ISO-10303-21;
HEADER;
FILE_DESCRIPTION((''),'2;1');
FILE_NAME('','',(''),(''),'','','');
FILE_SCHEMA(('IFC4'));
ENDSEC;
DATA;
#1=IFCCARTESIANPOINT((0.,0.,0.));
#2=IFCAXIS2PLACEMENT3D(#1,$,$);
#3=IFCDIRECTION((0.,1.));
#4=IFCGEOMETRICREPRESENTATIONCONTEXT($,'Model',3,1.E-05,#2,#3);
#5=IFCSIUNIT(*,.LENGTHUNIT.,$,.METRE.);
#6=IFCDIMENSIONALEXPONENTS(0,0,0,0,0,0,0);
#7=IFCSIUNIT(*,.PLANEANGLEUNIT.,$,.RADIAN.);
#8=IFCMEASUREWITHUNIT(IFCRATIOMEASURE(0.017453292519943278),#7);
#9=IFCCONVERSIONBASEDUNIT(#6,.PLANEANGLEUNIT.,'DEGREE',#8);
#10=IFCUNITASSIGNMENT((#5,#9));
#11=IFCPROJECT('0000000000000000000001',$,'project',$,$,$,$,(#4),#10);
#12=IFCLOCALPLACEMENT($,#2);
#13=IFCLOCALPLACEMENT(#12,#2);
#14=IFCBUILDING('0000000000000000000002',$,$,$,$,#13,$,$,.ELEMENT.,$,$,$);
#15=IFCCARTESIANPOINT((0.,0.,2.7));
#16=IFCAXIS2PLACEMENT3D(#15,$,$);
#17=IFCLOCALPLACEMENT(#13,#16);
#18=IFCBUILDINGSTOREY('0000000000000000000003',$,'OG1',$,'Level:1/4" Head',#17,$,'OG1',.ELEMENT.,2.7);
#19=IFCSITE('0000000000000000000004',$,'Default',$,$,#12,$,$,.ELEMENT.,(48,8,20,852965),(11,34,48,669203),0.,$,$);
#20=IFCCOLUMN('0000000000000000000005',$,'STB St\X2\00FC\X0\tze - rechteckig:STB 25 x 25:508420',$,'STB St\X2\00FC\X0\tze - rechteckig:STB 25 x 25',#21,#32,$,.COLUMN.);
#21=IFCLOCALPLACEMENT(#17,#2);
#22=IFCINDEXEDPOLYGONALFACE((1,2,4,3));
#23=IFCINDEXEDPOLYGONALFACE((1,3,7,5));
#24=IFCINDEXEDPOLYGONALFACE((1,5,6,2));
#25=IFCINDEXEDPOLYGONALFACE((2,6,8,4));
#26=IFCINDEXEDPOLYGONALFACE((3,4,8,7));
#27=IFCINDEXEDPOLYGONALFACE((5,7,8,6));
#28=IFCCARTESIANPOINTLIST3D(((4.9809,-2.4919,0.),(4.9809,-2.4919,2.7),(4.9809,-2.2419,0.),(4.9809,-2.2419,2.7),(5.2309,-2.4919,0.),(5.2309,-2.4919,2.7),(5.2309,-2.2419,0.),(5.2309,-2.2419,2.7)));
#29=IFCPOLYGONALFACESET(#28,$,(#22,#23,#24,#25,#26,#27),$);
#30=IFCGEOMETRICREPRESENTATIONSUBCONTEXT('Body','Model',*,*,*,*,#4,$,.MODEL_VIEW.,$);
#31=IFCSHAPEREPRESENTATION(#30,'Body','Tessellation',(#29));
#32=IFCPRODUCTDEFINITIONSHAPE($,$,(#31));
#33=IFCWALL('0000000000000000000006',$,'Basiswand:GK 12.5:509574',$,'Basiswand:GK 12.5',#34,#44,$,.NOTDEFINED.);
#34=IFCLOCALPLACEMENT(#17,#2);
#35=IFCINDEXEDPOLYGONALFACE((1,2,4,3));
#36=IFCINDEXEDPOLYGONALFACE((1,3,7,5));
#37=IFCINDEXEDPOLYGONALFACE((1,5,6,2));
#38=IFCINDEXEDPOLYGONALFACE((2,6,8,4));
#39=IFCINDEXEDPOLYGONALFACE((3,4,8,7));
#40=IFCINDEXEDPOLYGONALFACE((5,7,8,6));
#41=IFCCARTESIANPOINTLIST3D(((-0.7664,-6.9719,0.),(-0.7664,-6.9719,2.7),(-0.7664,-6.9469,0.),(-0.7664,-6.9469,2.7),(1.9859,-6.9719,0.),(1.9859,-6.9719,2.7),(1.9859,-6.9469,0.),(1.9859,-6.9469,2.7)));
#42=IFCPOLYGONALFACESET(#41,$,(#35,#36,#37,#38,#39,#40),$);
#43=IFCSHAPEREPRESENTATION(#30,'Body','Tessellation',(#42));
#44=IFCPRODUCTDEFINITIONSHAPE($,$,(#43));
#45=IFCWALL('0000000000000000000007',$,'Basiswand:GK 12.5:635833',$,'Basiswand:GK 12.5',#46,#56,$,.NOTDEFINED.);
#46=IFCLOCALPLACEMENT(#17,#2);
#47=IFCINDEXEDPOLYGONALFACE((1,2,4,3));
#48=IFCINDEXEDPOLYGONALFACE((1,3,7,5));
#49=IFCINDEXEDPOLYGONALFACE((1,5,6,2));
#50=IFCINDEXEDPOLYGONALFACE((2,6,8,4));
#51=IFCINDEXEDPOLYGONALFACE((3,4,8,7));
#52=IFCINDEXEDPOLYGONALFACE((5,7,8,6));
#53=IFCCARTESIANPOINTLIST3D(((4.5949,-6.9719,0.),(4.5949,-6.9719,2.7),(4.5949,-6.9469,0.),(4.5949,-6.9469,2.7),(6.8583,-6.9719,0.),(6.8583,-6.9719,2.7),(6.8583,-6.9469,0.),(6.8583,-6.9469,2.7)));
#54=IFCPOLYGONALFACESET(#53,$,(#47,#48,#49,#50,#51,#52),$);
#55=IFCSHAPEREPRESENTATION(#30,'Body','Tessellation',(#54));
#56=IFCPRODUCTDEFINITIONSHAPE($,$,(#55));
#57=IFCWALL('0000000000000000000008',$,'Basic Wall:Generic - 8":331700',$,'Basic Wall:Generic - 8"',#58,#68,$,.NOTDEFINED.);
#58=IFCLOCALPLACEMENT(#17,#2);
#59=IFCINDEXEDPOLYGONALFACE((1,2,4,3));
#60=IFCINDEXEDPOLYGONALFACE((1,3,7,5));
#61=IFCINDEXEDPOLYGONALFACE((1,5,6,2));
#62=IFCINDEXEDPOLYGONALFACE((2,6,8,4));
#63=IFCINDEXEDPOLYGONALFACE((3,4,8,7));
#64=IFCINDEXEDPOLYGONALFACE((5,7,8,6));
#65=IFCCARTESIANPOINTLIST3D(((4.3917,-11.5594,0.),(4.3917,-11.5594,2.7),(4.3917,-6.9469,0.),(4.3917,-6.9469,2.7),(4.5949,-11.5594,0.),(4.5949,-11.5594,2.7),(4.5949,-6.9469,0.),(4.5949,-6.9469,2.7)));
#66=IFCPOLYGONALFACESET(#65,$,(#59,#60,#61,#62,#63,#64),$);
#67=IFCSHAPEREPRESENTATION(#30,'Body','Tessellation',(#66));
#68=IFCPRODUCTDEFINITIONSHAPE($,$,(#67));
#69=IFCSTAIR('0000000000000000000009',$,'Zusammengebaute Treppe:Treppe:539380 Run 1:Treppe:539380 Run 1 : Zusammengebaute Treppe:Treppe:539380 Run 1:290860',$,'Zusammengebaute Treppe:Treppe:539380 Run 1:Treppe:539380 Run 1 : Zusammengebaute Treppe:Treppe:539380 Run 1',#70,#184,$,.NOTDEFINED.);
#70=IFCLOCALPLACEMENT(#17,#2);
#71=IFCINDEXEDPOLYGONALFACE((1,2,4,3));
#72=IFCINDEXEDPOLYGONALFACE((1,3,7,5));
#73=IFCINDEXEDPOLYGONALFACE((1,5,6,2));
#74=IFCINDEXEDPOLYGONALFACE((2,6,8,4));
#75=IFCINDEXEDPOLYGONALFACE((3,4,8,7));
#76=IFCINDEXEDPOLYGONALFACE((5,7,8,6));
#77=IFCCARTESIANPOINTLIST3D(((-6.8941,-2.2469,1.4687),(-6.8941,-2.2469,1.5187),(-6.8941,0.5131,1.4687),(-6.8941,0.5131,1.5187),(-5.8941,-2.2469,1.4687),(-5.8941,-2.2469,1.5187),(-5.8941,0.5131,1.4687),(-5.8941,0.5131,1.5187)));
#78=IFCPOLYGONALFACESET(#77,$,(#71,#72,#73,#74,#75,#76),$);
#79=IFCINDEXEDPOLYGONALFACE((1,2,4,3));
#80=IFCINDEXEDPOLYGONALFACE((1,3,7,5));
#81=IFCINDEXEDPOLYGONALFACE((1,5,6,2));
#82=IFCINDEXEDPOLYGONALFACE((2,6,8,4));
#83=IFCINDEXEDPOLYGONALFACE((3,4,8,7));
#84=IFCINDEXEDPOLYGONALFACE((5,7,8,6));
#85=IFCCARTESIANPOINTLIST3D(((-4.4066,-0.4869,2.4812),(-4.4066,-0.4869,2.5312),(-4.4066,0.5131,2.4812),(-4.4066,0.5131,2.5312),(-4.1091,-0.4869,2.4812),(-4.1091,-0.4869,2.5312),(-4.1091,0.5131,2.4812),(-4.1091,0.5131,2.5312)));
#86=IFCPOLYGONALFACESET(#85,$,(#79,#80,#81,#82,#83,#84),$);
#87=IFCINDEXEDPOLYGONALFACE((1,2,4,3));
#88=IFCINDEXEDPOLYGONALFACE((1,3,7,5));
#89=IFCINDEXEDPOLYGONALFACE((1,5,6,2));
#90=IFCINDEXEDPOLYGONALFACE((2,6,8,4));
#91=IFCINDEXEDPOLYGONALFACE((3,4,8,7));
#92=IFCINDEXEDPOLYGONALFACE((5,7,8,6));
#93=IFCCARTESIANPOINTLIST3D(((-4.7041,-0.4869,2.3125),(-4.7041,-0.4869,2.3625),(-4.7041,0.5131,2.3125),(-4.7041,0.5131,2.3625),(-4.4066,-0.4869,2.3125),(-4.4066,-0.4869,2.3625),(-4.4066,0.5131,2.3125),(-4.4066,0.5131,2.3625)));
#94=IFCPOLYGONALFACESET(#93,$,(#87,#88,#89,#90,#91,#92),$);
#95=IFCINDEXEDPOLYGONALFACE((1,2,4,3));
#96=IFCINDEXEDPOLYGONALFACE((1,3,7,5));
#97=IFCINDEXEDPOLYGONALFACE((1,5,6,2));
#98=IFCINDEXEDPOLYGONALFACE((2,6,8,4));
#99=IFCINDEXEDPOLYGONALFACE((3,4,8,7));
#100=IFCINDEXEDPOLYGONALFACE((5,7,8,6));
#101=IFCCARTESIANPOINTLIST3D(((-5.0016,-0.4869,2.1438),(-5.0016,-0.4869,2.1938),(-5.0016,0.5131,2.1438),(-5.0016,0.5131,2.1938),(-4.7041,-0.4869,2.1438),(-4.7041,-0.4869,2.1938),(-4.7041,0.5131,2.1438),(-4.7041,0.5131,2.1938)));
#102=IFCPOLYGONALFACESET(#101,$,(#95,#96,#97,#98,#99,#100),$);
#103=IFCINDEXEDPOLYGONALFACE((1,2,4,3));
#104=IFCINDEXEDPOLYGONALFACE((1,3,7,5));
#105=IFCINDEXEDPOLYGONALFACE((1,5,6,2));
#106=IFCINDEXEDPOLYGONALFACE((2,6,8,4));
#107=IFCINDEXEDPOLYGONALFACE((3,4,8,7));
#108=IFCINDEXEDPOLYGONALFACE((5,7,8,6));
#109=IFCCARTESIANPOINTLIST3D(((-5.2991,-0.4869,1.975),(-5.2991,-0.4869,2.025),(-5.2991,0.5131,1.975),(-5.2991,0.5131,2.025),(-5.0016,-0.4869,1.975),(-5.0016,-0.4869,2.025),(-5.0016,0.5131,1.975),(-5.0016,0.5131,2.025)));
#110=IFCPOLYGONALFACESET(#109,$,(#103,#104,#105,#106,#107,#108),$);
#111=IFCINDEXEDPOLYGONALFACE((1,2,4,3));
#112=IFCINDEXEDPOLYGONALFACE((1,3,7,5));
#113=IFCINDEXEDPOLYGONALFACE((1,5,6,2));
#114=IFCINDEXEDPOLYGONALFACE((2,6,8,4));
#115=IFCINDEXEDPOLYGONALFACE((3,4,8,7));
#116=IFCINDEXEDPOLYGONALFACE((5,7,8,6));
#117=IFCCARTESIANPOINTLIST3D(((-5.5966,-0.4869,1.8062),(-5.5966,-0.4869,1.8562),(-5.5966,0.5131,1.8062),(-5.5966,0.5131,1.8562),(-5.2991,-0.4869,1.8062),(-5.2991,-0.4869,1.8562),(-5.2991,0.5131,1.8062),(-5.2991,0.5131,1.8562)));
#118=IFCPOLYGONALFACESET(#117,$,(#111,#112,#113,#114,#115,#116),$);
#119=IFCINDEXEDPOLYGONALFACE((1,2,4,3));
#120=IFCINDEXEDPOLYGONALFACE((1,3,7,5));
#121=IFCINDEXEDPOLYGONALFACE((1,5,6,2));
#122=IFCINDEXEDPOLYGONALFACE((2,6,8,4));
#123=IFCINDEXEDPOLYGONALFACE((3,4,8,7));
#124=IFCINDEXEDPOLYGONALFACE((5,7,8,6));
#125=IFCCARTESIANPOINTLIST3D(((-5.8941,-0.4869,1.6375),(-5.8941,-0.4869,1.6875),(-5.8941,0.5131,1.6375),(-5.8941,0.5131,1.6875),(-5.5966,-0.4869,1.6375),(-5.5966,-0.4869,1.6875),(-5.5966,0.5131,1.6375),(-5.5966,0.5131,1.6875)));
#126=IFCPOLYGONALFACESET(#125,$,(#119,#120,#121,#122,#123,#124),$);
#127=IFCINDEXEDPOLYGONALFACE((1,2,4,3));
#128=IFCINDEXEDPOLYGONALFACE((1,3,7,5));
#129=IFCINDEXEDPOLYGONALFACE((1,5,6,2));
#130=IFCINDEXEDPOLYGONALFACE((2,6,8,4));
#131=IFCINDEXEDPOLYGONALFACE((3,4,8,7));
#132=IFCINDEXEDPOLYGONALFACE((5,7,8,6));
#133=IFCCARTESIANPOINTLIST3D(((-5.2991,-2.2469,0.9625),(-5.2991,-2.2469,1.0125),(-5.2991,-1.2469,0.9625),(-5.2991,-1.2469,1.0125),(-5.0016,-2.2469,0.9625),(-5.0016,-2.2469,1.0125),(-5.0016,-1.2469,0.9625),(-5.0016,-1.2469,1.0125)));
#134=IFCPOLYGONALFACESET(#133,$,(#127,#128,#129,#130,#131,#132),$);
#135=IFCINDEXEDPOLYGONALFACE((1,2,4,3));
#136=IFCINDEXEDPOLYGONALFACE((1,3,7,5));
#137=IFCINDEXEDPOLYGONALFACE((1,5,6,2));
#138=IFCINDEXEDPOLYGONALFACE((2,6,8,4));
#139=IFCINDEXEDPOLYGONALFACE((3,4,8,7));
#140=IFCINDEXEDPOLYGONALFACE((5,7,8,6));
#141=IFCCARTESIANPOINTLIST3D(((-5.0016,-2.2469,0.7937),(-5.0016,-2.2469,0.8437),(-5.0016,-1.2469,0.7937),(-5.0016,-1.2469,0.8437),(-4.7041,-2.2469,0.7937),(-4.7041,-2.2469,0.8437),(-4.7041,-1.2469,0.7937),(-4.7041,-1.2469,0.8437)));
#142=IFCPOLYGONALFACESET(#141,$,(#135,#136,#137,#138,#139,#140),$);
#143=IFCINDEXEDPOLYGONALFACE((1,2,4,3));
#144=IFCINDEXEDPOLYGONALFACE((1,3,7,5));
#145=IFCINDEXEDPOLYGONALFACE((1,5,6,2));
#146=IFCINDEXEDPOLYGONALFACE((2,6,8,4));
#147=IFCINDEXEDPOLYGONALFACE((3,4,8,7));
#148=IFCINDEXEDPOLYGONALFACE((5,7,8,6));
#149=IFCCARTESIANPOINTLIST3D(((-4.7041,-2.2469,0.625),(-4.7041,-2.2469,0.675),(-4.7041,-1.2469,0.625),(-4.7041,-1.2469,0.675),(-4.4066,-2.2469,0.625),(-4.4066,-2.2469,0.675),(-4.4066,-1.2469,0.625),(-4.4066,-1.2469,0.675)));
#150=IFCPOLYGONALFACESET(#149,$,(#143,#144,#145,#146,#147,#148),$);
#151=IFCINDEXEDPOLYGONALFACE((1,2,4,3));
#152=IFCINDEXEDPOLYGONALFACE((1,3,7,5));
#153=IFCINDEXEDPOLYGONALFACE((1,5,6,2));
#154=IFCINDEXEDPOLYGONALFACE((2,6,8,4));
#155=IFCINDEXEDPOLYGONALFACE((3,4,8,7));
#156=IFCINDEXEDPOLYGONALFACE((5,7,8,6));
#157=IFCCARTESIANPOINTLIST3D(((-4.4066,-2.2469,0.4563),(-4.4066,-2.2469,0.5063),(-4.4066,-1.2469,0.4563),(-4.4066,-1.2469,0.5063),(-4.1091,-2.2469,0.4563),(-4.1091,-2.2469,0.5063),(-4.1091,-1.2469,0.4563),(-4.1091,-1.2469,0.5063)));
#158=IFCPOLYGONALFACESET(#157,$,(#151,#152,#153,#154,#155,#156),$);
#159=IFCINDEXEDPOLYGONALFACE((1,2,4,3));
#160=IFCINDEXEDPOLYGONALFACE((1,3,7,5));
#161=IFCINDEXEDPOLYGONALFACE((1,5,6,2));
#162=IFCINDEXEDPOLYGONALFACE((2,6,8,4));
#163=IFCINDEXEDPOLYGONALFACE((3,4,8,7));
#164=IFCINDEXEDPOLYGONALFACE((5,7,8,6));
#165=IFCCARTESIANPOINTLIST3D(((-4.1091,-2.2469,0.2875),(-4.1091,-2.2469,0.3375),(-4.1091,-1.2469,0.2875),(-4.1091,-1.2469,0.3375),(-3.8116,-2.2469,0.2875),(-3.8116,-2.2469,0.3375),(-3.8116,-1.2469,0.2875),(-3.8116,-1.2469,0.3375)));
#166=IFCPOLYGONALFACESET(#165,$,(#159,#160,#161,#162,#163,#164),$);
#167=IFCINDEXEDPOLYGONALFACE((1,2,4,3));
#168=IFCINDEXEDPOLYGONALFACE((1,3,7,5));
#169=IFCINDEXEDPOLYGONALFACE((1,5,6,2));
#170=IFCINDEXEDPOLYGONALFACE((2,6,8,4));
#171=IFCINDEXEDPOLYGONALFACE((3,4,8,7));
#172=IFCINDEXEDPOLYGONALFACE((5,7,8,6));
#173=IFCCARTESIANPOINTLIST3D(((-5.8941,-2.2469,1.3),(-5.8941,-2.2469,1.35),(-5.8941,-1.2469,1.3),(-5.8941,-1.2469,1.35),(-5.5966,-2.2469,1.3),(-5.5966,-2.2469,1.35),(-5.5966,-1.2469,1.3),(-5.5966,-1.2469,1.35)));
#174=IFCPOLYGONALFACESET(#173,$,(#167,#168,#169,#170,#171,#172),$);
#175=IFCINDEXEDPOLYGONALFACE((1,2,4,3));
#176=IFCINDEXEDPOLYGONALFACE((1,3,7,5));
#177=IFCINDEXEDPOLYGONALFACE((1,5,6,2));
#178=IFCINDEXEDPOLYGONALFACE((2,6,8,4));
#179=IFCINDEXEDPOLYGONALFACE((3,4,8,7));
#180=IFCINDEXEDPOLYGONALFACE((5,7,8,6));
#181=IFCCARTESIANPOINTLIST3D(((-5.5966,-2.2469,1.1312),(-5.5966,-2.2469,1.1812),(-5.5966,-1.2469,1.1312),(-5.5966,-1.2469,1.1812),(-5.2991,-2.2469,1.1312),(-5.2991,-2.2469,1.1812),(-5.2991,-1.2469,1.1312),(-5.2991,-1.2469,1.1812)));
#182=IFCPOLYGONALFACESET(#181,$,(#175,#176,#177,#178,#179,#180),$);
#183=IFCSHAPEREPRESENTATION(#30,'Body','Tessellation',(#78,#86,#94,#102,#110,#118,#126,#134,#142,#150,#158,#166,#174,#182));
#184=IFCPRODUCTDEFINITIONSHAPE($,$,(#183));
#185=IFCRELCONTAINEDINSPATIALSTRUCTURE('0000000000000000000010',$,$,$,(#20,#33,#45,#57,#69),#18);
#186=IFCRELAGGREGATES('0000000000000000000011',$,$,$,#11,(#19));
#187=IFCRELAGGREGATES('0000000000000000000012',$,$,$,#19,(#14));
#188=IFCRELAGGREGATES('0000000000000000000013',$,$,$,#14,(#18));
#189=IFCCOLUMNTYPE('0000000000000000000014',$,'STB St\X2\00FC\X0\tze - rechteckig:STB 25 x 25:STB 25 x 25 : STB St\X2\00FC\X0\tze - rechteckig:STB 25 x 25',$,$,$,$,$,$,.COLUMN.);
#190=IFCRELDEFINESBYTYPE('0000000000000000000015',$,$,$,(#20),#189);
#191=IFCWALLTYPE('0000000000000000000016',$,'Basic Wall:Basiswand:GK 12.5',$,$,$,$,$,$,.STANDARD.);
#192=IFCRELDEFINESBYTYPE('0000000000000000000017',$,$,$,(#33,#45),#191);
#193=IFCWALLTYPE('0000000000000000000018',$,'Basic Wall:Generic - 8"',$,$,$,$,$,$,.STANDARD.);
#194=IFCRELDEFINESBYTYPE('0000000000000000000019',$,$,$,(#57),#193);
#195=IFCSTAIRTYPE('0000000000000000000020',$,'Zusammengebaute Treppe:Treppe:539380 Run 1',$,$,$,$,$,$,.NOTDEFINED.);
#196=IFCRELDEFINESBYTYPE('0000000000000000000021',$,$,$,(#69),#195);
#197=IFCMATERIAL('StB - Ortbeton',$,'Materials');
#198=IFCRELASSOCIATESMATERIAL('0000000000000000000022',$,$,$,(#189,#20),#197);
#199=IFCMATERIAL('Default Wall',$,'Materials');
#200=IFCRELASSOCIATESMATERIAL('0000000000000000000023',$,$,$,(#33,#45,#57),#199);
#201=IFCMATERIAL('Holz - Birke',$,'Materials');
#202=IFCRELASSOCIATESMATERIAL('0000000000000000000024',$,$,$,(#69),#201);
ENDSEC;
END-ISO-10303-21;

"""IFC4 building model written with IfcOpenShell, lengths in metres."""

from ifc_helpers import new_model, entity, si_unit, converted_unit, direction, frame, origin, place, context, subcontext, project, spatial, indexed_curve, outline, extrude, source, transform, mapped, material, type_object, type_shapes, element, save


model = new_model("IFC4")

# Units and contexts
model_context = context("Model", 3, precision=1e-05, world=origin(), true_north=direction((0.0, 1.0)))
body_context = subcontext(model_context, "Body", "Model", "MODEL_VIEW")
ifc_project = project(units=[si_unit("LENGTHUNIT", "METRE"), converted_unit("PLANEANGLEUNIT", "DEGREE", entity("IfcRatioMeasure", 0.017453292519943278), si_unit("PLANEANGLEUNIT", "RADIAN"), dimensions=[0, 0, 0, 0, 0, 0, 0])], contexts=[model_context])

# Site, building, storey
site_placement = place(None, origin())
site = spatial("IfcSite", under=ifc_project, at=site_placement, Name="Default", CompositionType="ELEMENT", RefLatitude=(48, 8, 20, 852965), RefLongitude=(11, 34, 48, 669203), RefElevation=0.0)
building_placement = place(site_placement, origin())
building = spatial("IfcBuilding", under=site, at=building_placement, CompositionType="ELEMENT")
storey_placement = place(building_placement, frame((0.0, 0.0, 2.7)))
storey = spatial("IfcBuildingStorey", under=building, at=storey_placement, Name="OG1", ObjectType="Level:1/4\" Head", LongName="OG1", CompositionType="ELEMENT", Elevation=2.7)

# Column
ifc_material_1 = material(Name="StB - Ortbeton", Category="Materials")
column_type = type_object("IfcColumnType", Name="STB Stütze - rechteckig:STB 25 x 25:STB 25 x 25 : STB Stütze - rechteckig:STB 25 x 25", PredefinedType="COLUMN", material=ifc_material_1)
shared_shape_1 = source(origin(), body_context, "Body", "SweptSolid", [
    extrude(outline(indexed_curve([(-0.125, -0.125), (0.125, -0.125), (0.125, 0.125), (-0.125, 0.125), (-0.125, -0.125)], self_intersect=False)), frame((0.0, 0.0, 2.7), z_axis=(0.0, 0.0, 1.0), x_axis=(0.0, -1.0, 0.0)), (0.0, 0.0, 1.0), 2.7),
])
type_shapes(column_type, [shared_shape_1])
column_placement = place(storey_placement, frame((5.1059, -2.3669, -2.7)))
element("IfcColumn", 1, at=column_placement, inside=storey, type_object=column_type, material=ifc_material_1, Name="STB Stütze - rechteckig:STB 25 x 25:508420", ObjectType="STB Stütze - rechteckig:STB 25 x 25", PredefinedType="COLUMN", context=body_context, shape_type="MappedRepresentation", body=[
    mapped(shared_shape_1, transform((0.0, 0.0, 0.0), scale=1.0)),
])

# Walls
ifc_material_2 = material(Name="Default Wall", Category="Materials")
wall_type_1 = type_object("IfcWallType", Name="Basic Wall:Basiswand:GK 12.5", PredefinedType="STANDARD")
wall_1_placement = place(storey_placement, frame((1.9859, -6.9594, 0.0), z_axis=(0.0, 0.0, 1.0), x_axis=(-1.0, 0.0, 0.0)))
element("IfcWall", 2, at=wall_1_placement, inside=storey, type_object=wall_type_1, material=ifc_material_2, Name="Basiswand:GK 12.5:509574", ObjectType="Basiswand:GK 12.5", PredefinedType="NOTDEFINED", context=body_context, shape_type="SweptSolid", body=[
    extrude(outline(indexed_curve([(2.7524, 0.0125), (0.0, 0.0125), (0.0, -0.0125), (2.7524, -0.0125), (2.7524, 0.0125)], self_intersect=False)), origin(), (0.0, 0.0, 1.0), 2.7),
])
wall_2_placement = place(storey_placement, frame((4.5949, -6.9594, 0.0)))
element("IfcWall", 3, at=wall_2_placement, inside=storey, type_object=wall_type_1, material=ifc_material_2, Name="Basiswand:GK 12.5:635833", ObjectType="Basiswand:GK 12.5", PredefinedType="NOTDEFINED", context=body_context, shape_type="SweptSolid", body=[
    extrude(outline(indexed_curve([(2.2634, 0.0125), (0.0, 0.0125), (0.0, -0.0125), (2.2634, -0.0125), (2.2634, 0.0125)], self_intersect=False)), origin(), (0.0, 0.0, 1.0), 2.7),
])
wall_type_2 = type_object("IfcWallType", Name="Basic Wall:Generic - 8\"", PredefinedType="STANDARD")
wall_3_placement = place(storey_placement, frame((4.4933, -6.9469, 0.0), z_axis=(0.0, 0.0, 1.0), x_axis=(0.0, -1.0, 0.0)))
element("IfcWall", 4, at=wall_3_placement, inside=storey, type_object=wall_type_2, material=ifc_material_2, Name="Basic Wall:Generic - 8\":331700", ObjectType="Basic Wall:Generic - 8\"", PredefinedType="NOTDEFINED", context=body_context, shape_type="SweptSolid", body=[
    extrude(outline(indexed_curve([(4.6125, 0.1016), (0.0, 0.1016), (0.0, -0.1016), (4.6125, -0.1016), (4.6125, 0.1016)], self_intersect=False)), origin(), (0.0, 0.0, 1.0), 2.7),
])

# Stair
ifc_material_3 = material(Name="Holz - Birke", Category="Materials")
stair_type_1 = type_object("IfcStairType", Name="Zusammengebaute Treppe:Treppe:539380 Run 1", PredefinedType="NOTDEFINED")
stair_1_placement = place(storey_placement, origin())
element("IfcStair", 5, at=stair_1_placement, inside=storey, type_object=stair_type_1, material=ifc_material_3, Name="Zusammengebaute Treppe:Treppe:539380 Run 1:Treppe:539380 Run 1 : Zusammengebaute Treppe:Treppe:539380 Run 1:290860", ObjectType="Zusammengebaute Treppe:Treppe:539380 Run 1:Treppe:539380 Run 1 : Zusammengebaute Treppe:Treppe:539380 Run 1", PredefinedType="NOTDEFINED", context=body_context, shape_type="SweptSolid", body=[
    extrude(outline(indexed_curve([(-0.5, -1.38), (0.5, -1.38), (0.5, 1.38), (-0.5, 1.38), (-0.5, -1.38)], self_intersect=False)), frame((-6.3941, -0.8669, 1.4687), z_axis=(0.0, 0.0, 1.0), x_axis=(-1.0, 0.0, 0.0)), (0.0, 0.0, 1.0), 0.05),
    extrude(outline(indexed_curve([(-0.5, -0.1488), (0.5, -0.1488), (0.5, 0.1488), (-0.5, 0.1488), (-0.5, -0.1488)], self_intersect=False)), frame((-4.2578, 0.0131, 2.4813), z_axis=(0.0, 0.0, 1.0), x_axis=(0.0, -1.0, 0.0)), (0.0, 0.0, 1.0), 0.05),
    extrude(outline(indexed_curve([(-0.5, -0.1488), (0.5, -0.1488), (0.5, 0.1488), (-0.5, 0.1488), (-0.5, -0.1488)], self_intersect=False)), frame((-4.5553, 0.0131, 2.3125), z_axis=(0.0, 0.0, 1.0), x_axis=(0.0, -1.0, 0.0)), (0.0, 0.0, 1.0), 0.05),
    extrude(outline(indexed_curve([(-0.5, -0.1488), (0.5, -0.1488), (0.5, 0.1488), (-0.5, 0.1488), (-0.5, -0.1488)], self_intersect=False)), frame((-4.8528, 0.0131, 2.1438), z_axis=(0.0, 0.0, 1.0), x_axis=(0.0, -1.0, 0.0)), (0.0, 0.0, 1.0), 0.05),
    extrude(outline(indexed_curve([(-0.5, -0.1487), (0.5, -0.1487), (0.5, 0.1488), (-0.5, 0.1488), (-0.5, -0.1487)], self_intersect=False)), frame((-5.1503, 0.0131, 1.975), z_axis=(0.0, 0.0, 1.0), x_axis=(0.0, -1.0, 0.0)), (0.0, 0.0, 1.0), 0.05),
    extrude(outline(indexed_curve([(-0.5, -0.1487), (0.5, -0.1487), (0.5, 0.1488), (-0.5, 0.1488), (-0.5, -0.1487)], self_intersect=False)), frame((-5.4478, 0.0131, 1.8062), z_axis=(0.0, 0.0, 1.0), x_axis=(0.0, -1.0, 0.0)), (0.0, 0.0, 1.0), 0.05),
    extrude(outline(indexed_curve([(-0.5, -0.1487), (0.5, -0.1487), (0.5, 0.1487), (-0.5, 0.1487), (-0.5, -0.1487)], self_intersect=False)), frame((-5.7453, 0.0131, 1.6375), z_axis=(0.0, 0.0, 1.0), x_axis=(0.0, -1.0, 0.0)), (0.0, 0.0, 1.0), 0.05),
    extrude(outline(indexed_curve([(-0.5, -0.1487), (0.5, -0.1487), (0.5, 0.1487), (-0.5, 0.1487), (-0.5, -0.1487)], self_intersect=False)), frame((-5.1503, -1.7469, 0.9625), z_axis=(0.0, 0.0, 1.0), x_axis=(0.0, 1.0, 0.0)), (0.0, 0.0, 1.0), 0.05),
    extrude(outline(indexed_curve([(-0.5, -0.1487), (0.5, -0.1487), (0.5, 0.1487), (-0.5, 0.1487), (-0.5, -0.1487)], self_intersect=False)), frame((-4.8528, -1.7469, 0.7937), z_axis=(0.0, 0.0, 1.0), x_axis=(0.0, 1.0, 0.0)), (0.0, 0.0, 1.0), 0.05),
    extrude(outline(indexed_curve([(-0.5, -0.1487), (0.5, -0.1487), (0.5, 0.1488), (-0.5, 0.1488), (-0.5, -0.1487)], self_intersect=False)), frame((-4.5553, -1.7469, 0.625), z_axis=(0.0, 0.0, 1.0), x_axis=(0.0, 1.0, 0.0)), (0.0, 0.0, 1.0), 0.05),
    extrude(outline(indexed_curve([(-0.5, -0.1487), (0.5, -0.1487), (0.5, 0.1488), (-0.5, 0.1488), (-0.5, -0.1487)], self_intersect=False)), frame((-4.2578, -1.7469, 0.4563), z_axis=(0.0, 0.0, 1.0), x_axis=(0.0, 1.0, 0.0)), (0.0, 0.0, 1.0), 0.05),
    extrude(outline(indexed_curve([(-0.5, -0.1487), (0.5, -0.1487), (0.5, 0.1487), (-0.5, 0.1487), (-0.5, -0.1487)], self_intersect=False)), frame((-3.9603, -1.7469, 0.2875), z_axis=(0.0, 0.0, 1.0), x_axis=(0.0, 1.0, 0.0)), (0.0, 0.0, 1.0), 0.05),
    extrude(outline(indexed_curve([(-0.5, -0.1487), (0.5, -0.1487), (0.5, 0.1487), (-0.5, 0.1487), (-0.5, -0.1487)], self_intersect=False)), frame((-5.7453, -1.7469, 1.3), z_axis=(0.0, 0.0, 1.0), x_axis=(0.0, 1.0, 0.0)), (0.0, 0.0, 1.0), 0.05),
    extrude(outline(indexed_curve([(-0.5, -0.1487), (0.5, -0.1487), (0.5, 0.1487), (-0.5, 0.1487), (-0.5, -0.1487)], self_intersect=False)), frame((-5.4478, -1.7469, 1.1313), z_axis=(0.0, 0.0, 1.0), x_axis=(0.0, 1.0, 0.0)), (0.0, 0.0, 1.0), 0.05),
])

save(model, "model.ifc")
